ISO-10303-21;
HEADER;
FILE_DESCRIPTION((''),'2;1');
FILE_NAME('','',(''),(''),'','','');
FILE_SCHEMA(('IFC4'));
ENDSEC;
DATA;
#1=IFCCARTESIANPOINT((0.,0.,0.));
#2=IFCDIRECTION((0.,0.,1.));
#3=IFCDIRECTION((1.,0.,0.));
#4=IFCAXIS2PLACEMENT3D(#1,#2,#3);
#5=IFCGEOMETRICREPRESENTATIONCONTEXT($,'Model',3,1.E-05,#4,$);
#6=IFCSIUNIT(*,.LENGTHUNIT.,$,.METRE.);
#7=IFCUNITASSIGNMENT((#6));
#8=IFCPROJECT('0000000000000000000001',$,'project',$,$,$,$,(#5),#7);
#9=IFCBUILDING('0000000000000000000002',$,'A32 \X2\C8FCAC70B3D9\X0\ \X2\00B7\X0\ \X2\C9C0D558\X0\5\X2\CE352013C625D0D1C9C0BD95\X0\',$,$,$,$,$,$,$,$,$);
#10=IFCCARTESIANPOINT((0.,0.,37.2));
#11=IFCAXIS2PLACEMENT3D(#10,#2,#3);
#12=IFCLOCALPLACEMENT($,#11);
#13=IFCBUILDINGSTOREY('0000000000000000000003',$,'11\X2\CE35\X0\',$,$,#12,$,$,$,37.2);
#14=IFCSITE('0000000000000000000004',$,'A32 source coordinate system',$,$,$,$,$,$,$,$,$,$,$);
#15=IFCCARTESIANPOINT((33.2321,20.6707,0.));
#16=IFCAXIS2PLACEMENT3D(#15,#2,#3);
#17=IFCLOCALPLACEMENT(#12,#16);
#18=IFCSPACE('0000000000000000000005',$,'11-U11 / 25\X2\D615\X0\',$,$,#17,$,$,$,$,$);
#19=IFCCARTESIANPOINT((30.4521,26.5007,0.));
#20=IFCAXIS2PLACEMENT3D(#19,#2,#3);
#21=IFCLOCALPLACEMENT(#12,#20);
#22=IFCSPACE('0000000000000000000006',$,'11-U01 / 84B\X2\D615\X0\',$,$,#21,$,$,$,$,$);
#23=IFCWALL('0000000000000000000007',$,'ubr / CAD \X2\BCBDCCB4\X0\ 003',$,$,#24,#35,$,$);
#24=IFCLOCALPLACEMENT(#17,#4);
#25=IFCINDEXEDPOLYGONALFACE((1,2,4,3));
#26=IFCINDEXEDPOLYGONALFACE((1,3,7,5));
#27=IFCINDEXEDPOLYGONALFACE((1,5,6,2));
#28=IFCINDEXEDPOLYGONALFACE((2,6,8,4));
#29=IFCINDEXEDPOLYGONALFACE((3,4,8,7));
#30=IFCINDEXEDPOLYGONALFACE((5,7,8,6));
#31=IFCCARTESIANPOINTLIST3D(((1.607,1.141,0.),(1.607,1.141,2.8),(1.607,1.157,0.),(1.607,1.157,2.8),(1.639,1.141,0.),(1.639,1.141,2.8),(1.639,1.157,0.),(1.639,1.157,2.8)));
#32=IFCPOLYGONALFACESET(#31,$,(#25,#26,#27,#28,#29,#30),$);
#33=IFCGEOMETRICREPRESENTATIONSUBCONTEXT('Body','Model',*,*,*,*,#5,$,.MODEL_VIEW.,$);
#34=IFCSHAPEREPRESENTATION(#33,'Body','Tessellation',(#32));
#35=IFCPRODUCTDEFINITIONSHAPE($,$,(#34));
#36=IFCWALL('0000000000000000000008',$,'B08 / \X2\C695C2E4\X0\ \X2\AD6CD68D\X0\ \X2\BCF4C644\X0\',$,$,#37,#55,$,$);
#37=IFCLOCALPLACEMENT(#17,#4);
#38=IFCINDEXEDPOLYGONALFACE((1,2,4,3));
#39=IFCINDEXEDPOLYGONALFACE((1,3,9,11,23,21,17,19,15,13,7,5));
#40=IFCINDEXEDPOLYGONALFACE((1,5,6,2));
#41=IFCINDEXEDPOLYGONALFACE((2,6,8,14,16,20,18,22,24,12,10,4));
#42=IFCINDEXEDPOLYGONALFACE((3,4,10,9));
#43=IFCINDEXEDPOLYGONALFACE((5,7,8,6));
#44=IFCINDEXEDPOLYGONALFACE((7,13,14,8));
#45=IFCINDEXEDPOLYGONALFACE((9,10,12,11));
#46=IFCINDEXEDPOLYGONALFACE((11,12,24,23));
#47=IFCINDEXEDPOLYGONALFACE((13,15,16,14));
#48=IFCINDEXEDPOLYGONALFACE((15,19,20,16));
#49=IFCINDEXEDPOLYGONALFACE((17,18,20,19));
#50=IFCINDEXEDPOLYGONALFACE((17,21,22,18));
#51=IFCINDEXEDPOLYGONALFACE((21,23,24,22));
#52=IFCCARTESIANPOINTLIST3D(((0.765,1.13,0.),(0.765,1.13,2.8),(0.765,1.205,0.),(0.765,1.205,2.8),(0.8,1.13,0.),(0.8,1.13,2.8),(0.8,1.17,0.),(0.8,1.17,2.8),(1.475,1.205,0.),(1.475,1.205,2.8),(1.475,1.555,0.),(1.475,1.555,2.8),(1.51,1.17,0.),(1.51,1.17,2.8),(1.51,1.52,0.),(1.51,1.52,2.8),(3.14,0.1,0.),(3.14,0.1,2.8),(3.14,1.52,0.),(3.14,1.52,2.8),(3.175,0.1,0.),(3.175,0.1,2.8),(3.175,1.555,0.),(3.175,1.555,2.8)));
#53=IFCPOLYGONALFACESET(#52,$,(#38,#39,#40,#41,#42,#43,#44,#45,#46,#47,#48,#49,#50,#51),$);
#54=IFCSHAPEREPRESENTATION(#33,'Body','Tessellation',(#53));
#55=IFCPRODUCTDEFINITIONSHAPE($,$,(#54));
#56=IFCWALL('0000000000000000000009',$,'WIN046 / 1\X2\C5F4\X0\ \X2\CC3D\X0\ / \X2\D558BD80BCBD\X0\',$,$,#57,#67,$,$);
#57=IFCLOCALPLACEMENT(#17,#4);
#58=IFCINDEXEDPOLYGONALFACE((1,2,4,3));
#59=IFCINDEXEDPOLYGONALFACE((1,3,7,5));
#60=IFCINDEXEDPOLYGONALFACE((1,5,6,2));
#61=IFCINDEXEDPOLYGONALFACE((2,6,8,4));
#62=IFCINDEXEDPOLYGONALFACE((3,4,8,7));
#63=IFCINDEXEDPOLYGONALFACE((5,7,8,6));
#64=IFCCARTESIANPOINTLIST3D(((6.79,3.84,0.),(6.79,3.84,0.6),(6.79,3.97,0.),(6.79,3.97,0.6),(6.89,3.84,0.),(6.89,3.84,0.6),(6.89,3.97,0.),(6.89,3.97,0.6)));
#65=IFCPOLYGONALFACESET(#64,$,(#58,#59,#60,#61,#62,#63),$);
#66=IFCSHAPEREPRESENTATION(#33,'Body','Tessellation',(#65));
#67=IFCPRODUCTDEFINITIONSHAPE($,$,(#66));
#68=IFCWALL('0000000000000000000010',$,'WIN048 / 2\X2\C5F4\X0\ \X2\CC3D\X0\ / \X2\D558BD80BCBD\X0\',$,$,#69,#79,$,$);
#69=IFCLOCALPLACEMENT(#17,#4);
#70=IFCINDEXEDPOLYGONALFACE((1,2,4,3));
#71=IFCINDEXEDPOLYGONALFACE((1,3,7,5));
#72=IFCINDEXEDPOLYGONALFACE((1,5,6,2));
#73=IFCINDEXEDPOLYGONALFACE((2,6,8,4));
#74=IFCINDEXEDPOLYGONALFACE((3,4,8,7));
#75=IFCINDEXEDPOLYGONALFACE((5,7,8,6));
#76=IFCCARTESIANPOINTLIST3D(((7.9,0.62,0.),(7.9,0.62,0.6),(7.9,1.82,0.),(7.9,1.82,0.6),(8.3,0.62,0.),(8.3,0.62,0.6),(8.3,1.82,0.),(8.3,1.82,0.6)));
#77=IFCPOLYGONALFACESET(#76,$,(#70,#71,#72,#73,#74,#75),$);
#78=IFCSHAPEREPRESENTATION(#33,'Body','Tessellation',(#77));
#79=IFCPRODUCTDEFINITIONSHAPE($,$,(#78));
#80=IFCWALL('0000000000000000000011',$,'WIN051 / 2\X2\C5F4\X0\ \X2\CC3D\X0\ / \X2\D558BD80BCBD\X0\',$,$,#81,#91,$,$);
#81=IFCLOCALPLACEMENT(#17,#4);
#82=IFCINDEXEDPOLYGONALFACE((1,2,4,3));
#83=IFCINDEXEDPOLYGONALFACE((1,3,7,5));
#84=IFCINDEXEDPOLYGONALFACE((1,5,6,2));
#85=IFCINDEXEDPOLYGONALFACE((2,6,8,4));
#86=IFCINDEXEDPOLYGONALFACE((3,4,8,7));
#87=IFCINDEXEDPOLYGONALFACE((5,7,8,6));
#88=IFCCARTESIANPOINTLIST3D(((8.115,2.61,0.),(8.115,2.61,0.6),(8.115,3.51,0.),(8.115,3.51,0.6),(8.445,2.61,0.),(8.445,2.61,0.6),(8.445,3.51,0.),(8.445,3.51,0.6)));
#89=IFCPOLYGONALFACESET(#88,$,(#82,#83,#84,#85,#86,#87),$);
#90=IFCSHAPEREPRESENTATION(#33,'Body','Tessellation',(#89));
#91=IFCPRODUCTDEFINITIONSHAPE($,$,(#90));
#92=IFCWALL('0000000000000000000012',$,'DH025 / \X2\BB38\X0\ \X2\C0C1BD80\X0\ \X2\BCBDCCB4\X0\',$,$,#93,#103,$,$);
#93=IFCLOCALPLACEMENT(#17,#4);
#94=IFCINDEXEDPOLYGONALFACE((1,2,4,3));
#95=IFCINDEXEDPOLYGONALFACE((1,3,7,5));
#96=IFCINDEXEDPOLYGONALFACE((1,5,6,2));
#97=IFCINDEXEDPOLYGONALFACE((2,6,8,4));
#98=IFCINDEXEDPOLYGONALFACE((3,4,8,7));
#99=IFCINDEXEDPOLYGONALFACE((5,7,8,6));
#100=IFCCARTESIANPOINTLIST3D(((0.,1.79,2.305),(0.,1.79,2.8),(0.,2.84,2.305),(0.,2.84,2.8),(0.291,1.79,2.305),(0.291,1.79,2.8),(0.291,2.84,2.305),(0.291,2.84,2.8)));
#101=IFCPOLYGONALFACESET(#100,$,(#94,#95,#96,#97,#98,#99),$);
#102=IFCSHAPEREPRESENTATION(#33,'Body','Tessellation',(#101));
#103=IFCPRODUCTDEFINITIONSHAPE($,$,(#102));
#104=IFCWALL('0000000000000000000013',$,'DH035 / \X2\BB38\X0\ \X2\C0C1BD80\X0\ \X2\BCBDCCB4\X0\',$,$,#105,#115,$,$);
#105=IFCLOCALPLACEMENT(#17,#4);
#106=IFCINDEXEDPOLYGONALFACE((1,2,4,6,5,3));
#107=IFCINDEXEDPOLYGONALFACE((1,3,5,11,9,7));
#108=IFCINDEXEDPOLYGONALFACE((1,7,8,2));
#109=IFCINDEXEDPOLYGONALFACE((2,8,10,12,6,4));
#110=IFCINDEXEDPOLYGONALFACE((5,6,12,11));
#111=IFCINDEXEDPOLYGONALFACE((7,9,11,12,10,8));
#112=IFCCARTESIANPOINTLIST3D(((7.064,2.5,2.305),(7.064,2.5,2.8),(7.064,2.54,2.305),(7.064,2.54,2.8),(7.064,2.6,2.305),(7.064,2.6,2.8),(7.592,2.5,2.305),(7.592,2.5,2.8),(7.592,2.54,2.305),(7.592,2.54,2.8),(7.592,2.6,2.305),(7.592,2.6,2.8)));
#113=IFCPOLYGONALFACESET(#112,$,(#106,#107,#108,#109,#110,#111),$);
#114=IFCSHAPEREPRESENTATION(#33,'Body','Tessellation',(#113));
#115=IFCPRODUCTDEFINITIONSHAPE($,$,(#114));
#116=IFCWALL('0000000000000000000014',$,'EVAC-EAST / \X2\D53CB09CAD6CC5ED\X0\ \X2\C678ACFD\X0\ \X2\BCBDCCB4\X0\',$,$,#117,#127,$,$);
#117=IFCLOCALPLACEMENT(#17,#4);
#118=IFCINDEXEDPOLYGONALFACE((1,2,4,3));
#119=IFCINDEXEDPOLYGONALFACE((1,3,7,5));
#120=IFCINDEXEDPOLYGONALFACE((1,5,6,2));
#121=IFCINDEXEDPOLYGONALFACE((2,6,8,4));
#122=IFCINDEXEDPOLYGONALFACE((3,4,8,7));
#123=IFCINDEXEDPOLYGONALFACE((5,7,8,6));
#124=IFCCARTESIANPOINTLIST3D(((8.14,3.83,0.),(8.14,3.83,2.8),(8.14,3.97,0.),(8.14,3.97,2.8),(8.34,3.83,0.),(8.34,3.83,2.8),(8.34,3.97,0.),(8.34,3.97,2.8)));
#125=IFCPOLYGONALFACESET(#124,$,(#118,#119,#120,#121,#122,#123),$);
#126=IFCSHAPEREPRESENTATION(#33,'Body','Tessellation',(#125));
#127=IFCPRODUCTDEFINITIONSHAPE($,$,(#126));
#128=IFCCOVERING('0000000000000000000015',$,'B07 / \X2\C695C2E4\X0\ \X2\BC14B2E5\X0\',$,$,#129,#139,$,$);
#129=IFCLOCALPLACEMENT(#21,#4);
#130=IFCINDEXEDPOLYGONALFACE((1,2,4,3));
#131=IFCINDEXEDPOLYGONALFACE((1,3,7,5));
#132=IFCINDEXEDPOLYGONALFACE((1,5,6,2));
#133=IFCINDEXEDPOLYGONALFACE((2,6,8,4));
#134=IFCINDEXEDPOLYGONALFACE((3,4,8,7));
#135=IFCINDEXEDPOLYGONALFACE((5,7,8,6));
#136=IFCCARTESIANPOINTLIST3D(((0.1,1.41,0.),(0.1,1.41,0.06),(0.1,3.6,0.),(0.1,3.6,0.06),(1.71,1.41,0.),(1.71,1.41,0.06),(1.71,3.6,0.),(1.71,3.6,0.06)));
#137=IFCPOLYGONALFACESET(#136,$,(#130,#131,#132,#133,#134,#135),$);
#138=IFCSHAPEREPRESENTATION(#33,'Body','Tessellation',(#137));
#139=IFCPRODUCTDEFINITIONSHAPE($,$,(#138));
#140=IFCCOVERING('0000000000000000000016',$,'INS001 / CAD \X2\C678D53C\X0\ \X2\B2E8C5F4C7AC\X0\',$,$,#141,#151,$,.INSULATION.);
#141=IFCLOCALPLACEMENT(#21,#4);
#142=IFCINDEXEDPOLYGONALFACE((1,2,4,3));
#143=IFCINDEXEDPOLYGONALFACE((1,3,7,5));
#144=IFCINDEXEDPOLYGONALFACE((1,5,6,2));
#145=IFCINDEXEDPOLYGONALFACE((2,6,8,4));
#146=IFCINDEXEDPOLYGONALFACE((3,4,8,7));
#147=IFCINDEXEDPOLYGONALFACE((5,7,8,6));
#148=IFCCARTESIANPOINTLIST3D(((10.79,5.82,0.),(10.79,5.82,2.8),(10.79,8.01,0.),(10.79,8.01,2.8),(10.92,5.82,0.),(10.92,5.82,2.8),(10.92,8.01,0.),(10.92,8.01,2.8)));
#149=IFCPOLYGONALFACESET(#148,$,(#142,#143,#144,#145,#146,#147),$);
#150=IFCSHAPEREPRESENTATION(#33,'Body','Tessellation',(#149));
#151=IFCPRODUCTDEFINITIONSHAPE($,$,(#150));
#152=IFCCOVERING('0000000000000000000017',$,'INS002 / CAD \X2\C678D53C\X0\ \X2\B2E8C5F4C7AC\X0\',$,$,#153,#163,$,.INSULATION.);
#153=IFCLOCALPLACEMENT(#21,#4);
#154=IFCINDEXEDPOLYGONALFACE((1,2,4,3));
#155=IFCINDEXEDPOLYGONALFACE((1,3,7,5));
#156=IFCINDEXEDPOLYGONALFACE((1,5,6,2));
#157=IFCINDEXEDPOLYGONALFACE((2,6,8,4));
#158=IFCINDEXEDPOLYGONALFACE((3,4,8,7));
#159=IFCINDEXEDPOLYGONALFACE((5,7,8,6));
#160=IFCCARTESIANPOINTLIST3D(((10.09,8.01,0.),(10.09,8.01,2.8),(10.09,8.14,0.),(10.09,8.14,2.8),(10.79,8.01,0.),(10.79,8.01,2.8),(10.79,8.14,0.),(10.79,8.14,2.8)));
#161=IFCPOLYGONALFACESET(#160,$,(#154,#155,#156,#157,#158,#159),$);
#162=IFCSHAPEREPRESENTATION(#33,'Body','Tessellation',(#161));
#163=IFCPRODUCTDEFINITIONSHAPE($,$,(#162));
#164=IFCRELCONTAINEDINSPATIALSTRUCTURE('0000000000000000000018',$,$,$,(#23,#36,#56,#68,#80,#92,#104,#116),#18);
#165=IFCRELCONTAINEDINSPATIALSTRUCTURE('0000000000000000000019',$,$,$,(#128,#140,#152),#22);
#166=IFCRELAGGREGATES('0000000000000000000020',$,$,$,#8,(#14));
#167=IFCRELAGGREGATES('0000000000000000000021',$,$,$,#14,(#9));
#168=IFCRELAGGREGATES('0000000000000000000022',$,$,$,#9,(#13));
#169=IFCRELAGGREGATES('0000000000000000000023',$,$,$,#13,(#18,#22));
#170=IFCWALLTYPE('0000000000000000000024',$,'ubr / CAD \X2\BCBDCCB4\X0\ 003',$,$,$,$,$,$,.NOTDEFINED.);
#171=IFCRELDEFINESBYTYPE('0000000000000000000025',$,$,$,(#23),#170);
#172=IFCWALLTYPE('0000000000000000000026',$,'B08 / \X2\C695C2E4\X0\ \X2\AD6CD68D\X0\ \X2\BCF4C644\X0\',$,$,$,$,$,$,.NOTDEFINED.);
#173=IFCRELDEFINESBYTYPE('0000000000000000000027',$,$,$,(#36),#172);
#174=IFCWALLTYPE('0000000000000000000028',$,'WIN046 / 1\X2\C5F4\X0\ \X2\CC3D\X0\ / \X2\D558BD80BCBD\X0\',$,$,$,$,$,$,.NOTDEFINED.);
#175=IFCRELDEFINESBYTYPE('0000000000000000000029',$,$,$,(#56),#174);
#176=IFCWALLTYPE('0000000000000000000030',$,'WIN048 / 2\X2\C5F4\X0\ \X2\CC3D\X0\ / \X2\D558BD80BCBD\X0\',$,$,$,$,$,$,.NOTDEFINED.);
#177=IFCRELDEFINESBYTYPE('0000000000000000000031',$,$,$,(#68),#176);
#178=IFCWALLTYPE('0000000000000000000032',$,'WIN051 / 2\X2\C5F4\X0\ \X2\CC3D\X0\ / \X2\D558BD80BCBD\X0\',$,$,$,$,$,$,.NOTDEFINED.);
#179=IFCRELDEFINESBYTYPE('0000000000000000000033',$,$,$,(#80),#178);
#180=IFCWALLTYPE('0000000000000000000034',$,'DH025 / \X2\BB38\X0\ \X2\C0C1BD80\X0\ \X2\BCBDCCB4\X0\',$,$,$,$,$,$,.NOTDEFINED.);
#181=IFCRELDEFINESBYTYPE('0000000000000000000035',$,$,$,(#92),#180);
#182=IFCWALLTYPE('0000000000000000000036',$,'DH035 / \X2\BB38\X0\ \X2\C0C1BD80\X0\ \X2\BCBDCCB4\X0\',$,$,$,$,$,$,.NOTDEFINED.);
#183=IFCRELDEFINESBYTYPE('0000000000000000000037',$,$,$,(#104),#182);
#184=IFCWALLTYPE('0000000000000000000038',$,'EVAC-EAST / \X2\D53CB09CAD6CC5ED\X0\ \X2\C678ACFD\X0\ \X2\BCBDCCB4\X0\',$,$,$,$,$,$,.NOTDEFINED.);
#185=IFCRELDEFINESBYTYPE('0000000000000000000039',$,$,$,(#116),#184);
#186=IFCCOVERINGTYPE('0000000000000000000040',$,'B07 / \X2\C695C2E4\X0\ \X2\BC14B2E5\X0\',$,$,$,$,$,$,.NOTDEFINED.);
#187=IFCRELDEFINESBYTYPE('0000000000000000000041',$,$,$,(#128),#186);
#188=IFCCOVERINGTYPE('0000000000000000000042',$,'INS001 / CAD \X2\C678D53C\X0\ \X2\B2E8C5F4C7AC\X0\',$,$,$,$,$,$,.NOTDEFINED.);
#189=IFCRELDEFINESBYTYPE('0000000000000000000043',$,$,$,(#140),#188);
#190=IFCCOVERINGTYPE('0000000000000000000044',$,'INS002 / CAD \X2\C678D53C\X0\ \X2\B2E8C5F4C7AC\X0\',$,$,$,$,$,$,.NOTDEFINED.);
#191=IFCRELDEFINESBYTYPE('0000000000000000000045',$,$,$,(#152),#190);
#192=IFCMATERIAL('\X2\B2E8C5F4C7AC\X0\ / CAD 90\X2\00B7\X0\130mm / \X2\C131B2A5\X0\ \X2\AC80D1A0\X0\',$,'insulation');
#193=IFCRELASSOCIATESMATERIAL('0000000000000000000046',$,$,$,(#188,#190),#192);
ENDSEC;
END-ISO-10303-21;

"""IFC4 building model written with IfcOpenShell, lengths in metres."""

from ifc_helpers import new_model, si_unit, frame, origin, origin_with_axes, place, context, subcontext, project, spatial, polyline, outline, extrude, source, transform, mapped, material, type_object, type_shapes, element, save


model = new_model("IFC4")

# Units and contexts
model_context = context("Model", 3, precision=1e-05, world=origin_with_axes())
body_context = subcontext(model_context, "Body", "Model", "MODEL_VIEW")
ifc_project = project(units=[si_unit("LENGTHUNIT", "METRE")], contexts=[model_context])

# Site, building, storey, space
site = spatial("IfcSite", under=ifc_project, Name="A32 source coordinate system")
building = spatial("IfcBuilding", under=site, Name="A32 주거동 · 지하5층–옥탑지붕")
storey_placement = place(None, frame((0.0, 0.0, 37.2), z_axis=(0.0, 0.0, 1.0), x_axis=(1.0, 0.0, 0.0)))
storey = spatial("IfcBuildingStorey", under=building, at=storey_placement, Name="11층", Elevation=37.2)
space_1_placement = place(storey_placement, frame((33.2321, 20.6707, 0.0), z_axis=(0.0, 0.0, 1.0), x_axis=(1.0, 0.0, 0.0)))
space_1 = spatial("IfcSpace", under=storey, at=space_1_placement, Name="11-U11 / 25형")

# Walls
wall_type_1 = type_object("IfcWallType", Name="ubr / CAD 벽체 003", PredefinedType="NOTDEFINED")
shared_shape_1 = source(origin(), body_context, "Body", "SweptSolid", [
    extrude(outline(polyline([(1.639, 1.157), (1.639, 1.141), (1.607, 1.141), (1.607, 1.157), (1.639, 1.157)])), origin(), (0.0, 0.0, 1.0), 2.8),
])
type_shapes(wall_type_1, [shared_shape_1])
wall_1_placement = place(space_1_placement, origin_with_axes())
element("IfcWall", 1, at=wall_1_placement, inside=space_1, type_object=wall_type_1, Name="ubr / CAD 벽체 003", context=body_context, shape_type="MappedRepresentation", body=[
    mapped(shared_shape_1, transform((0.0, 0.0, 0.0), scale=1.0)),
])
wall_type_2 = type_object("IfcWallType", Name="B08 / 욕실 구획 보완", PredefinedType="NOTDEFINED")
shared_shape_2 = source(origin(), body_context, "Body", "SweptSolid", [
    extrude(outline(polyline([(0.765, 1.205), (1.475, 1.205), (1.475, 1.555), (3.175, 1.555), (3.175, 0.1), (3.14, 0.1), (3.14, 1.52), (1.51, 1.52), (1.51, 1.17), (0.8, 1.17), (0.8, 1.13), (0.765, 1.13), (0.765, 1.205)])), origin(), (0.0, 0.0, 1.0), 2.8),
])
type_shapes(wall_type_2, [shared_shape_2])
wall_2_placement = place(space_1_placement, origin_with_axes())
element("IfcWall", 2, at=wall_2_placement, inside=space_1, type_object=wall_type_2, Name="B08 / 욕실 구획 보완", context=body_context, shape_type="MappedRepresentation", body=[
    mapped(shared_shape_2, transform((0.0, 0.0, 0.0), scale=1.0)),
])
wall_type_3 = type_object("IfcWallType", Name="WIN046 / 1열 창 / 하부벽", PredefinedType="NOTDEFINED")
shared_shape_3 = source(origin(), body_context, "Body", "SweptSolid", [
    extrude(outline(polyline([(6.89, 3.84), (6.79, 3.84), (6.79, 3.97), (6.89, 3.97), (6.89, 3.84)])), origin(), (0.0, 0.0, 1.0), 0.6),
])
type_shapes(wall_type_3, [shared_shape_3])
wall_3_placement = place(space_1_placement, origin_with_axes())
element("IfcWall", 3, at=wall_3_placement, inside=space_1, type_object=wall_type_3, Name="WIN046 / 1열 창 / 하부벽", context=body_context, shape_type="MappedRepresentation", body=[
    mapped(shared_shape_3, transform((0.0, 0.0, 0.0), scale=1.0)),
])
wall_type_4 = type_object("IfcWallType", Name="WIN048 / 2열 창 / 하부벽", PredefinedType="NOTDEFINED")
shared_shape_4 = source(origin(), body_context, "Body", "SweptSolid", [
    extrude(outline(polyline([(8.3, 0.62), (7.9, 0.62), (7.9, 1.82), (8.3, 1.82), (8.3, 0.62)])), origin(), (0.0, 0.0, 1.0), 0.6),
])
type_shapes(wall_type_4, [shared_shape_4])
wall_4_placement = place(space_1_placement, origin_with_axes())
element("IfcWall", 4, at=wall_4_placement, inside=space_1, type_object=wall_type_4, Name="WIN048 / 2열 창 / 하부벽", context=body_context, shape_type="MappedRepresentation", body=[
    mapped(shared_shape_4, transform((0.0, 0.0, 0.0), scale=1.0)),
])
wall_type_5 = type_object("IfcWallType", Name="WIN051 / 2열 창 / 하부벽", PredefinedType="NOTDEFINED")
shared_shape_5 = source(origin(), body_context, "Body", "SweptSolid", [
    extrude(outline(polyline([(8.445, 2.61), (8.115, 2.61), (8.115, 3.51), (8.445, 3.51), (8.445, 2.61)])), origin(), (0.0, 0.0, 1.0), 0.6),
])
type_shapes(wall_type_5, [shared_shape_5])
wall_5_placement = place(space_1_placement, origin_with_axes())
element("IfcWall", 5, at=wall_5_placement, inside=space_1, type_object=wall_type_5, Name="WIN051 / 2열 창 / 하부벽", context=body_context, shape_type="MappedRepresentation", body=[
    mapped(shared_shape_5, transform((0.0, 0.0, 0.0), scale=1.0)),
])
wall_type_6 = type_object("IfcWallType", Name="DH025 / 문 상부 벽체", PredefinedType="NOTDEFINED")
shared_shape_6 = source(origin(), body_context, "Body", "SweptSolid", [
    extrude(outline(polyline([(0.0, 1.79), (0.0, 2.84), (0.291, 2.84), (0.291, 1.79), (0.0, 1.79)])), frame((0.0, 0.0, 2.305)), (0.0, 0.0, 1.0), 0.495),
])
type_shapes(wall_type_6, [shared_shape_6])
wall_6_placement = place(space_1_placement, origin_with_axes())
element("IfcWall", 6, at=wall_6_placement, inside=space_1, type_object=wall_type_6, Name="DH025 / 문 상부 벽체", context=body_context, shape_type="MappedRepresentation", body=[
    mapped(shared_shape_6, transform((0.0, 0.0, 0.0), scale=1.0)),
])
wall_type_7 = type_object("IfcWallType", Name="DH035 / 문 상부 벽체", PredefinedType="NOTDEFINED")
shared_shape_7 = source(origin(), body_context, "Body", "SweptSolid", [
    extrude(outline(polyline([(7.592, 2.6), (7.592, 2.54), (7.592, 2.5), (7.064, 2.5), (7.064, 2.54), (7.064, 2.6), (7.592, 2.6)])), frame((0.0, 0.0, 2.305)), (0.0, 0.0, 1.0), 0.495),
])
type_shapes(wall_type_7, [shared_shape_7])
wall_7_placement = place(space_1_placement, origin_with_axes())
element("IfcWall", 7, at=wall_7_placement, inside=space_1, type_object=wall_type_7, Name="DH035 / 문 상부 벽체", context=body_context, shape_type="MappedRepresentation", body=[
    mapped(shared_shape_7, transform((0.0, 0.0, 0.0), scale=1.0)),
])
wall_type_8 = type_object("IfcWallType", Name="EVAC-EAST / 피난구역 외곽 벽체", PredefinedType="NOTDEFINED")
shared_shape_8 = source(origin(), body_context, "Body", "SweptSolid", [
    extrude(outline(polyline([(8.34, 3.83), (8.14, 3.83), (8.14, 3.97), (8.34, 3.97), (8.34, 3.83)])), origin(), (0.0, 0.0, 1.0), 2.8),
])
type_shapes(wall_type_8, [shared_shape_8])
wall_8_placement = place(space_1_placement, origin_with_axes())
element("IfcWall", 8, at=wall_8_placement, inside=space_1, type_object=wall_type_8, Name="EVAC-EAST / 피난구역 외곽 벽체", context=body_context, shape_type="MappedRepresentation", body=[
    mapped(shared_shape_8, transform((0.0, 0.0, 0.0), scale=1.0)),
])

# Shared definitions
space_2_placement = place(storey_placement, frame((30.4521, 26.5007, 0.0), z_axis=(0.0, 0.0, 1.0), x_axis=(1.0, 0.0, 0.0)))
space_2 = spatial("IfcSpace", under=storey, at=space_2_placement, Name="11-U01 / 84B형")

# Coverings
covering_type_1 = type_object("IfcCoveringType", Name="B07 / 욕실 바닥", PredefinedType="NOTDEFINED")
shared_shape_9 = source(origin(), body_context, "Body", "SweptSolid", [
    extrude(outline(polyline([(1.71, 1.41), (0.1, 1.41), (0.1, 3.6), (1.71, 3.6), (1.71, 1.41)])), origin(), (0.0, 0.0, 1.0), 0.06),
])
type_shapes(covering_type_1, [shared_shape_9])
covering_1_placement = place(space_2_placement, origin_with_axes())
element("IfcCovering", 9, at=covering_1_placement, inside=space_2, type_object=covering_type_1, Name="B07 / 욕실 바닥", context=body_context, shape_type="MappedRepresentation", body=[
    mapped(shared_shape_9, transform((0.0, 0.0, 0.0), scale=1.0)),
])
ifc_material = material(Name="단열재 / CAD 90·130mm / 성능 검토", Category="insulation")
covering_type_2 = type_object("IfcCoveringType", Name="INS001 / CAD 외피 단열재", PredefinedType="NOTDEFINED", material=ifc_material)
shared_shape_10 = source(origin(), body_context, "Body", "SweptSolid", [
    extrude(outline(polyline([(10.79, 5.82), (10.79, 8.01), (10.92, 8.01), (10.92, 5.82), (10.79, 5.82)])), origin(), (0.0, 0.0, 1.0), 2.8),
])
type_shapes(covering_type_2, [shared_shape_10])
covering_2_placement = place(space_2_placement, origin_with_axes())
element("IfcCovering", 10, at=covering_2_placement, inside=space_2, type_object=covering_type_2, Name="INS001 / CAD 외피 단열재", PredefinedType="INSULATION", context=body_context, shape_type="MappedRepresentation", body=[
    mapped(shared_shape_10, transform((0.0, 0.0, 0.0), scale=1.0)),
])
covering_type_3 = type_object("IfcCoveringType", Name="INS002 / CAD 외피 단열재", PredefinedType="NOTDEFINED", material=ifc_material)
shared_shape_11 = source(origin(), body_context, "Body", "SweptSolid", [
    extrude(outline(polyline([(10.79, 8.01), (10.09, 8.01), (10.09, 8.14), (10.79, 8.14), (10.79, 8.01)])), origin(), (0.0, 0.0, 1.0), 2.8),
])
type_shapes(covering_type_3, [shared_shape_11])
covering_3_placement = place(space_2_placement, origin_with_axes())
element("IfcCovering", 11, at=covering_3_placement, inside=space_2, type_object=covering_type_3, Name="INS002 / CAD 외피 단열재", PredefinedType="INSULATION", context=body_context, shape_type="MappedRepresentation", body=[
    mapped(shared_shape_11, transform((0.0, 0.0, 0.0), scale=1.0)),
])

save(model, "model.ifc")
